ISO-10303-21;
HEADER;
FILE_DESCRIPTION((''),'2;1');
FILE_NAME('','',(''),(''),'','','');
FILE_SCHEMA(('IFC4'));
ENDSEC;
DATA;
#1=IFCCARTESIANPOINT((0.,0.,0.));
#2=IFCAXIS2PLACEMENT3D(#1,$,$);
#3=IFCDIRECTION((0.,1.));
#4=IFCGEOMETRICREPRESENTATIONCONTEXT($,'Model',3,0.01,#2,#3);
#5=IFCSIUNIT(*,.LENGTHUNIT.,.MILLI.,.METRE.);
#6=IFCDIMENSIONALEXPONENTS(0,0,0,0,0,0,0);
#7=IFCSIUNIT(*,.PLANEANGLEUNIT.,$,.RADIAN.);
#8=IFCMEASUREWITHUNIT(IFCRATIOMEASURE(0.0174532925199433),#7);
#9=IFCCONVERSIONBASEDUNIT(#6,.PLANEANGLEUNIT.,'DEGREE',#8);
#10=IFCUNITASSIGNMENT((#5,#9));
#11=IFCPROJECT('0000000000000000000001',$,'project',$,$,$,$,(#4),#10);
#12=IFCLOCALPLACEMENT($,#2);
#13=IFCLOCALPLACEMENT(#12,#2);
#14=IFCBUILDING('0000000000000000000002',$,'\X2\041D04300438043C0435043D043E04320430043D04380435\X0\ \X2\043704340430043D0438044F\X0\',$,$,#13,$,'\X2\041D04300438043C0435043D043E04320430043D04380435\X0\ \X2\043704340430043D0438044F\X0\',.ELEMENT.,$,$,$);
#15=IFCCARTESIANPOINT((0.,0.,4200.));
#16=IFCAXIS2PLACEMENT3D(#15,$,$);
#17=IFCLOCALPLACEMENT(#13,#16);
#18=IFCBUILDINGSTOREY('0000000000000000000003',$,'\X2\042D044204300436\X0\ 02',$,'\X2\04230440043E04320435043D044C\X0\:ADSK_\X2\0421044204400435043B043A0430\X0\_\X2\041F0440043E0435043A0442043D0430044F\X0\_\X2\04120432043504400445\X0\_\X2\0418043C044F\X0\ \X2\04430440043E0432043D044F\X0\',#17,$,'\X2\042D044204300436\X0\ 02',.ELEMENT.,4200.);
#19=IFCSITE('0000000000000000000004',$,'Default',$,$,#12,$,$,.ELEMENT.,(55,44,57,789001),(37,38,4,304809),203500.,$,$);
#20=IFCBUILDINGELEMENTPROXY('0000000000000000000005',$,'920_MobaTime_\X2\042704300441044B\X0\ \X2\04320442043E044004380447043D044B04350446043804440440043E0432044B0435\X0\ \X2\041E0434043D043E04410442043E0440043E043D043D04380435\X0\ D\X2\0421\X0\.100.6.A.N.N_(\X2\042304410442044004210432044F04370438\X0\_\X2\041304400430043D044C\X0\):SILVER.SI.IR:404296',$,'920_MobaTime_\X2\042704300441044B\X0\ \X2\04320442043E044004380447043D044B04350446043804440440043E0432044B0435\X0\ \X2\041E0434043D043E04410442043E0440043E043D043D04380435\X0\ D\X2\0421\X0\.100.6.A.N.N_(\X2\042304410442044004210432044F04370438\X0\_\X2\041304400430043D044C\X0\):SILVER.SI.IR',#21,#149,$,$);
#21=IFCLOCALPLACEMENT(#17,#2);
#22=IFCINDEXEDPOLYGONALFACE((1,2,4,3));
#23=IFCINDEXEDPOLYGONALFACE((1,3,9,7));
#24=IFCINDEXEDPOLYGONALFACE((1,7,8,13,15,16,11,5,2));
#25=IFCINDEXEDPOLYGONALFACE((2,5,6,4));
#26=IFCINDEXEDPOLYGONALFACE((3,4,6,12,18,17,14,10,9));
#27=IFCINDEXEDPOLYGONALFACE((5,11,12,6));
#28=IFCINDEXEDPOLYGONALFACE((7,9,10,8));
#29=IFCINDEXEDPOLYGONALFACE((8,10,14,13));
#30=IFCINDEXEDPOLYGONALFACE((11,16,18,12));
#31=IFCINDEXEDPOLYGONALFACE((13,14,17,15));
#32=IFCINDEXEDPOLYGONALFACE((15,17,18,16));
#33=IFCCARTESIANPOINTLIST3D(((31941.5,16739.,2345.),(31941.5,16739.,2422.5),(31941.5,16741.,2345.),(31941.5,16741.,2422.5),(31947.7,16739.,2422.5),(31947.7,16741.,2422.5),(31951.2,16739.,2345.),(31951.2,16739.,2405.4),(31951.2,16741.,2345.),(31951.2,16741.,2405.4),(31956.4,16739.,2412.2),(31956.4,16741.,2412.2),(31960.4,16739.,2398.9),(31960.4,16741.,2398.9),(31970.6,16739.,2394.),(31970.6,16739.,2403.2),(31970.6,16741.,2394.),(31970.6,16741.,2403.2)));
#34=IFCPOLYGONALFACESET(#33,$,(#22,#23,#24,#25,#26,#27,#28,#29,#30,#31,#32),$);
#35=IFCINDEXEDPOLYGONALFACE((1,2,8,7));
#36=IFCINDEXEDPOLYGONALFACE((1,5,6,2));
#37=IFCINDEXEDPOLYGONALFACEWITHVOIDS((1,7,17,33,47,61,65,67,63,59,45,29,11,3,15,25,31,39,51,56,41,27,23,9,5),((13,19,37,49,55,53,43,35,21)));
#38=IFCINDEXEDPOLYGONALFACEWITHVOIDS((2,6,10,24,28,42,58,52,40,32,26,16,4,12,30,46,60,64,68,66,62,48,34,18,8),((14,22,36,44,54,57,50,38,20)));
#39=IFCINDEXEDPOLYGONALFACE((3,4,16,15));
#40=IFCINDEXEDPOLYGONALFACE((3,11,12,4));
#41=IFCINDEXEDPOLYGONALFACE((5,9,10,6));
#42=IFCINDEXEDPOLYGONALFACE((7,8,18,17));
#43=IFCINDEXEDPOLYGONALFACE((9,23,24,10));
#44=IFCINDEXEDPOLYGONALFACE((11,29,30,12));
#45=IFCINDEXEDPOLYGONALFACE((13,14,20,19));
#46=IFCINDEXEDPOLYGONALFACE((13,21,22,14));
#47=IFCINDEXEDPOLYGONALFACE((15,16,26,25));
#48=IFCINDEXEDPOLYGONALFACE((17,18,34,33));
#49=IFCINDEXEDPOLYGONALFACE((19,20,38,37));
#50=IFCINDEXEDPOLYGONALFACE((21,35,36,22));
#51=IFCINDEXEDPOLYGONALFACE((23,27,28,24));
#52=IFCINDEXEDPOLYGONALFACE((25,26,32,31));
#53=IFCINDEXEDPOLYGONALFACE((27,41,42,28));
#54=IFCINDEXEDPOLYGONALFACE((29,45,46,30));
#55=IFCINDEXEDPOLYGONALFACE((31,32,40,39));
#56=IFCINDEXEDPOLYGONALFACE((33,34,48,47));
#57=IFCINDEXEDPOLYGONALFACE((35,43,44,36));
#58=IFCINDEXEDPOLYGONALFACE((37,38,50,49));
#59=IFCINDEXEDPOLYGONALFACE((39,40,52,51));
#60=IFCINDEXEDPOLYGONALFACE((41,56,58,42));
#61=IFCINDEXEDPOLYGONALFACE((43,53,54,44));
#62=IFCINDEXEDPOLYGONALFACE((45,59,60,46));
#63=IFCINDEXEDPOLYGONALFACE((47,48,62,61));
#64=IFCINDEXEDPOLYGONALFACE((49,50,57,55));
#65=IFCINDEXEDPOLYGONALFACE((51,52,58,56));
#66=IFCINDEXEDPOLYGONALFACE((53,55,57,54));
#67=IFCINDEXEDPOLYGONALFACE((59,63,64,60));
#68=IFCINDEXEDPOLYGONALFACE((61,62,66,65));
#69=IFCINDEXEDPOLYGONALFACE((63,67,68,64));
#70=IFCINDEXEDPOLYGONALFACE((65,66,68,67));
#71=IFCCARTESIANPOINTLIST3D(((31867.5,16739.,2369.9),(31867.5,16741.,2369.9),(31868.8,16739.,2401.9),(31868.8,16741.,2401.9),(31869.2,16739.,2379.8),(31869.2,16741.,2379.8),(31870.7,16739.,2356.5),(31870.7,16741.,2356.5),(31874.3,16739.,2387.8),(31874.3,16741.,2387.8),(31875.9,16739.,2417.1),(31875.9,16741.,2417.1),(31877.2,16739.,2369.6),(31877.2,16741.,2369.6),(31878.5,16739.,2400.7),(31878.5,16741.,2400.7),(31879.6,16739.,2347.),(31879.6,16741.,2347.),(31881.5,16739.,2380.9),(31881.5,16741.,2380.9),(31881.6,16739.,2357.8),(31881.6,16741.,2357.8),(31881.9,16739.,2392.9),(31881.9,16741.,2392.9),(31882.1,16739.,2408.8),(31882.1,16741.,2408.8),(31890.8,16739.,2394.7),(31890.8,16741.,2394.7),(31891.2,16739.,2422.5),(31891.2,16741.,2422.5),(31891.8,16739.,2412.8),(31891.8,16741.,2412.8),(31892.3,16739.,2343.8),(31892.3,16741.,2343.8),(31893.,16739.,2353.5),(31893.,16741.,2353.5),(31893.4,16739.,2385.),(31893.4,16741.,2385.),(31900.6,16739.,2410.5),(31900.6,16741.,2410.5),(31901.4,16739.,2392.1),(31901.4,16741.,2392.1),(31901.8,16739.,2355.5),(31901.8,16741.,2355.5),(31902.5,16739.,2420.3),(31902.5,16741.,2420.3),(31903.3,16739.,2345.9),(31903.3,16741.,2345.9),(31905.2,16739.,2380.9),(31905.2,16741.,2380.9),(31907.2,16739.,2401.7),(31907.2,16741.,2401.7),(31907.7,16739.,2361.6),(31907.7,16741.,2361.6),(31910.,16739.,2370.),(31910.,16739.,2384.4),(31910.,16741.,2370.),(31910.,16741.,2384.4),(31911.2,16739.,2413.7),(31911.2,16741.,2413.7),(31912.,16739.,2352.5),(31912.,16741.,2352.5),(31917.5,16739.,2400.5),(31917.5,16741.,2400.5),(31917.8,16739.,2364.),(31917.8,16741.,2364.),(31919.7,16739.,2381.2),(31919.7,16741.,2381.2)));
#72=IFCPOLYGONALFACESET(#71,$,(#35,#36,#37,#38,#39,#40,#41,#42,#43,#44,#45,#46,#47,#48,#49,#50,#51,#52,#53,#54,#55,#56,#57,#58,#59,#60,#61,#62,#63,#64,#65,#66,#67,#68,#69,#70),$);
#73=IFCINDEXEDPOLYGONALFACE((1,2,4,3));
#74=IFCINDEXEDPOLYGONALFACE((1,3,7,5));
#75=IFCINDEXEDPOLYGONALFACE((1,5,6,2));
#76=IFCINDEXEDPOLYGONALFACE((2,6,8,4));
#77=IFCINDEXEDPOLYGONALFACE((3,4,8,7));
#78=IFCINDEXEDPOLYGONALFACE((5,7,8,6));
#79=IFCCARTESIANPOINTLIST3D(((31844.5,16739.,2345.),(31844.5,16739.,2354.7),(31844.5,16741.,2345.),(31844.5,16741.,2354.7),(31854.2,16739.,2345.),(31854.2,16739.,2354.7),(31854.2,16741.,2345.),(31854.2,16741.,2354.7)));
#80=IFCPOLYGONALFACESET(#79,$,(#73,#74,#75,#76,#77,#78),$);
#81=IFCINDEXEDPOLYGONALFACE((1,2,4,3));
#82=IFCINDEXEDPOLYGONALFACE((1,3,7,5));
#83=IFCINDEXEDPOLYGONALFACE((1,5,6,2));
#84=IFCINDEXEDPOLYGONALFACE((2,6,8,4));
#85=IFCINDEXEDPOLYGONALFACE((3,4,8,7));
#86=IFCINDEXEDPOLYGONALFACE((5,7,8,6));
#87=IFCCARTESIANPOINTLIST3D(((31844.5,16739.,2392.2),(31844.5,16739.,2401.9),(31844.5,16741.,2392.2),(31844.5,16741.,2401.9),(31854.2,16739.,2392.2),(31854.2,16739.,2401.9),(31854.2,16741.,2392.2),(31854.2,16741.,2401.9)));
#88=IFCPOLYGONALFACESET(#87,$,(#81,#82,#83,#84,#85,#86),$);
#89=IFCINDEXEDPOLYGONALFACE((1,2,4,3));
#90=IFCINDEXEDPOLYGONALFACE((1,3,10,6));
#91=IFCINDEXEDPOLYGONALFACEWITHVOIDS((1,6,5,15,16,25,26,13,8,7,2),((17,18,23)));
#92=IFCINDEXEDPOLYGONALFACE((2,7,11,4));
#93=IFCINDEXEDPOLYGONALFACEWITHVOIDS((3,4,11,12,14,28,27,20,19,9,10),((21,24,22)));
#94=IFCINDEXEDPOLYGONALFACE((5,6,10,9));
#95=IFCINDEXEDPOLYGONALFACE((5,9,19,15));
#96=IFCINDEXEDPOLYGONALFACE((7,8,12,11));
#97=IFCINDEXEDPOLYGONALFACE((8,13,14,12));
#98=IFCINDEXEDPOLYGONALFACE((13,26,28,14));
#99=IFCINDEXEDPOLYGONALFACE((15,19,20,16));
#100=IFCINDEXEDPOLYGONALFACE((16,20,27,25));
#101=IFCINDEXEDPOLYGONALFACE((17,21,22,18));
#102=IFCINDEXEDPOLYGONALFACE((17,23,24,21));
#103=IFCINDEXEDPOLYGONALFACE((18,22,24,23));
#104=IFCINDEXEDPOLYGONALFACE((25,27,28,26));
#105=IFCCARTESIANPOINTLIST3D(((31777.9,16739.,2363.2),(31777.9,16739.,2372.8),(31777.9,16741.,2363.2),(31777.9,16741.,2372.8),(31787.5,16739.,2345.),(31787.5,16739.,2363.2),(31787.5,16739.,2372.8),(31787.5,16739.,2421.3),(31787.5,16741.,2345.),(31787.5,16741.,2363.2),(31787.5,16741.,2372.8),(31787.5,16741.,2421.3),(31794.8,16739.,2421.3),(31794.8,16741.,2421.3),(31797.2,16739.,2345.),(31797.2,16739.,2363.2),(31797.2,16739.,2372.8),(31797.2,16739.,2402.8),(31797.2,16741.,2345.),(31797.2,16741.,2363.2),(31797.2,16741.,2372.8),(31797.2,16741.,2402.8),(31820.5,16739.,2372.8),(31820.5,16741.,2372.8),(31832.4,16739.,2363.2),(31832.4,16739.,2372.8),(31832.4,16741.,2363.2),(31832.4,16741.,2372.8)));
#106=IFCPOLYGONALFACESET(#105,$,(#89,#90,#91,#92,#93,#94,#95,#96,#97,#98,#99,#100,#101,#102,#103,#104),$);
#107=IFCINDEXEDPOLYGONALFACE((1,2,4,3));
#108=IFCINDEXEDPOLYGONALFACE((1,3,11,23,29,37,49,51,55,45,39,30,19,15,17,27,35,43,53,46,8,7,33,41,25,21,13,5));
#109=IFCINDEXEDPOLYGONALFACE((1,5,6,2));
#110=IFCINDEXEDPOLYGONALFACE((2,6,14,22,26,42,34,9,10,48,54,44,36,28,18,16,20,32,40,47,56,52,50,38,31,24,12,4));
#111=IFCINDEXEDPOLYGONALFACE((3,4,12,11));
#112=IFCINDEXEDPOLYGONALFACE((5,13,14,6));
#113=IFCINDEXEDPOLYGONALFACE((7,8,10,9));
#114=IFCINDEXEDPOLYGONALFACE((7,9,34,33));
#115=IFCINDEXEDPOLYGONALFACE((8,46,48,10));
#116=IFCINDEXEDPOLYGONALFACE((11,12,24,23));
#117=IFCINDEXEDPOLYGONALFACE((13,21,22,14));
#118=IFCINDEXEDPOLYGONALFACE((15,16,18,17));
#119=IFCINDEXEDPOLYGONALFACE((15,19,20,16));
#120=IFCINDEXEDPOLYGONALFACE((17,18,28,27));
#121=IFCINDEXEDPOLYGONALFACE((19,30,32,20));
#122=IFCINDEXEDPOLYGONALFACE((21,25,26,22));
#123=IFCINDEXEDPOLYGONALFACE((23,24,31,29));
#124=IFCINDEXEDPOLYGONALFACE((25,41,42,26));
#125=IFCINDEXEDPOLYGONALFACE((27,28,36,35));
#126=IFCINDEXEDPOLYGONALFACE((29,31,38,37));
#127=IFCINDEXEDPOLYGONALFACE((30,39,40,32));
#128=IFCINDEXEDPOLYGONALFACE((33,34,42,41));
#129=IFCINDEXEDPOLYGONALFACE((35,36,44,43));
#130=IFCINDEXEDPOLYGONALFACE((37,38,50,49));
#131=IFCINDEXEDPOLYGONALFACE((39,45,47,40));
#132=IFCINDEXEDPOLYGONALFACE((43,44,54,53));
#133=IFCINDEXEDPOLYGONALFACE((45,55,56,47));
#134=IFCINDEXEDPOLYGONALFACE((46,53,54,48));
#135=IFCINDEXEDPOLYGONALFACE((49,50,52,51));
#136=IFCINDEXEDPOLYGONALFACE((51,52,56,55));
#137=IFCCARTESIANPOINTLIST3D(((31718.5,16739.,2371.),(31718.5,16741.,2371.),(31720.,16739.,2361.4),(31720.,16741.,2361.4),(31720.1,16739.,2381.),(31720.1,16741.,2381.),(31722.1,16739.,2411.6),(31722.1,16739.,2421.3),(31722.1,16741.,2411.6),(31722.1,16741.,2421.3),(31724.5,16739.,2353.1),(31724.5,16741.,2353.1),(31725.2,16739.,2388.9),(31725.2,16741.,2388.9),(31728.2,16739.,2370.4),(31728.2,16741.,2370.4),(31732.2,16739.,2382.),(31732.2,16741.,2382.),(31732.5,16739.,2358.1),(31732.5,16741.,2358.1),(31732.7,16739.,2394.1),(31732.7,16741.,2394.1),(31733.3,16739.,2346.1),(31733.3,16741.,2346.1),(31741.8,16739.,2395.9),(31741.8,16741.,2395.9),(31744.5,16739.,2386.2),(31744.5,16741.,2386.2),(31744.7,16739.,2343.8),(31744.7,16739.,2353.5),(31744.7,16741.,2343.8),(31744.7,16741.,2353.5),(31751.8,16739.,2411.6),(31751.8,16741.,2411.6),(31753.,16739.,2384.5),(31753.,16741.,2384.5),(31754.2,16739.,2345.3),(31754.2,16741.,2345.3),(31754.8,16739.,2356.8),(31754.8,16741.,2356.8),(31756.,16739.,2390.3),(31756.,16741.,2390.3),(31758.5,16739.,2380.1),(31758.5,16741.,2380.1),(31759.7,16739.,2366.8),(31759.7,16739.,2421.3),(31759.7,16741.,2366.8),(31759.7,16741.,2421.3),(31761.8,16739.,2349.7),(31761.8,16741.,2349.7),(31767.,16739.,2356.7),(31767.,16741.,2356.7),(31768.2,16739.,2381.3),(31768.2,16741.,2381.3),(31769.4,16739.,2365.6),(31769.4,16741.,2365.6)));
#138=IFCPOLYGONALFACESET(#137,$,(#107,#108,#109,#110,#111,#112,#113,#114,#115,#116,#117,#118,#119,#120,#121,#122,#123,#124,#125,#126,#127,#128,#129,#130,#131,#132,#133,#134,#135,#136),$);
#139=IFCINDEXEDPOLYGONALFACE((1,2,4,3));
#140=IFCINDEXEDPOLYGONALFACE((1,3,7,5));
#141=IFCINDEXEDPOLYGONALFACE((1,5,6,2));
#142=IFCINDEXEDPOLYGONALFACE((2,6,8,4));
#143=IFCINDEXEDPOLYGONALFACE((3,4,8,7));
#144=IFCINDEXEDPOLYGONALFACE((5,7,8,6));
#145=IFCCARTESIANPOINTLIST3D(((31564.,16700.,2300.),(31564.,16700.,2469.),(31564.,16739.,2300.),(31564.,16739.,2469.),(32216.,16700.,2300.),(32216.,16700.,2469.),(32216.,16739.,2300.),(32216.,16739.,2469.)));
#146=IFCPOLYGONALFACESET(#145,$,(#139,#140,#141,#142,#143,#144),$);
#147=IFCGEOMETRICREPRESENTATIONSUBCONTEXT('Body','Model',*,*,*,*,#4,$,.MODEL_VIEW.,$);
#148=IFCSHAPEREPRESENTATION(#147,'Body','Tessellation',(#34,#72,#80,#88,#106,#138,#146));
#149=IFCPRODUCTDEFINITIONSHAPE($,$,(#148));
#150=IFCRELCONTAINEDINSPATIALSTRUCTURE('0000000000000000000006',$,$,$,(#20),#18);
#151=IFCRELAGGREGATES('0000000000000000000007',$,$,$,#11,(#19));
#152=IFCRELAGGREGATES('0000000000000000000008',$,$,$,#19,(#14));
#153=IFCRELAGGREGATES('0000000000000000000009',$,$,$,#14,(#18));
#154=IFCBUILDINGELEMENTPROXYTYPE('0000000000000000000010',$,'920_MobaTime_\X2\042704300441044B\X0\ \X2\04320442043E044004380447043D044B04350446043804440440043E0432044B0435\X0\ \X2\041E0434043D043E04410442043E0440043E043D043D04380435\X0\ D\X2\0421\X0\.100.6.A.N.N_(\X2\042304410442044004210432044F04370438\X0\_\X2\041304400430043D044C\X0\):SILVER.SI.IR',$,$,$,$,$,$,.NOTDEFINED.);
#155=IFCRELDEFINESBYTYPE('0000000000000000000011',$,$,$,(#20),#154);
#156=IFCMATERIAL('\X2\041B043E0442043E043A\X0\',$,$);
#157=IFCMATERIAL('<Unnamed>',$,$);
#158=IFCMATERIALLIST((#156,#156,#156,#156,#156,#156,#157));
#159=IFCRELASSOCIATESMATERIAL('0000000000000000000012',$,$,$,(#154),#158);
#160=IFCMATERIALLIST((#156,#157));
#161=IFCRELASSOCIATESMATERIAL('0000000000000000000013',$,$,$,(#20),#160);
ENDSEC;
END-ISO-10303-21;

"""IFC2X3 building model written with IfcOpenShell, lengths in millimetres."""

from ifc_helpers import new_model, entity, si_unit, converted_unit, direction, frame, origin, origin_2d_with_axis, place, context, subcontext, project, spatial, polyline, rectangle, outline, extrude, source, transform, mapped, material, material_list, type_object, type_shapes, element, save


model = new_model("IFC2X3")

# Units and contexts
model_context = context("Model", 3, precision=0.01, world=origin(), true_north=direction((0.0, 1.0)))
body_context = subcontext(model_context, "Body", "Model", "MODEL_VIEW")
ifc_project = project(units=[si_unit("LENGTHUNIT", "METRE", prefix="MILLI"), converted_unit("PLANEANGLEUNIT", "DEGREE", entity("IfcRatioMeasure", 0.0174532925199433), si_unit("PLANEANGLEUNIT", "RADIAN"), dimensions=[0, 0, 0, 0, 0, 0, 0])], contexts=[model_context])

# Site, building, storey
site_placement = place(None, frame((0.0, 0.0, 0.0)))
site = spatial("IfcSite", under=ifc_project, at=site_placement, Name="Default", CompositionType="ELEMENT", RefLatitude=(55, 44, 57, 789001), RefLongitude=(37, 38, 4, 304809), RefElevation=203500.0)
building_placement = place(site_placement, origin())
building = spatial("IfcBuilding", under=site, at=building_placement, Name="Наименование здания", LongName="Наименование здания", CompositionType="ELEMENT")
storey_placement = place(building_placement, frame((0.0, 0.0, 4200.0)))
storey = spatial("IfcBuildingStorey", under=building, at=storey_placement, Name="Этаж 02", ObjectType="Уровень:ADSK_Стрелка_Проектная_Вверх_Имя уровня", LongName="Этаж 02", CompositionType="ELEMENT", Elevation=4200.0)

# Building element proxy
ifc_material_1 = material(Name="Лоток")
ifc_material_2 = material(Name="<Unnamed>")
ifc_material_list_1 = material_list([ifc_material_1, ifc_material_1, ifc_material_1, ifc_material_1, ifc_material_1, ifc_material_1, ifc_material_2])
building_element_proxy_type_1 = type_object("IfcBuildingElementProxyType", Name="920_MobaTime_Часы вторичныецифровые Односторонние DС.100.6.A.N.N_(УстрСвязи_Грань):SILVER.SI.IR", PredefinedType="NOTDEFINED", material=ifc_material_list_1)
shared_shape_1 = source(origin(), body_context, "Body", "SweptSolid", [
    extrude(outline(polyline([(-49.3, -13.1), (28.2, -13.1), (28.2, -6.8), (17.9, 1.8), (8.9, 16.0), (-0.3, 16.0), (4.6, 5.8), (11.1, -3.4), (-49.3, -3.4), (-49.3, -13.1)])), frame((-64.6, 9.8, 39.0), z_axis=(0.0, 0.0, 1.0), x_axis=(0.0, 1.0, 0.0)), (0.0, 0.0, 1.0), 2.0),
    extrude(outline(polyline([(2.2, -27.6), (19.0, -27.6), (30.5, -16.1), (33.3, -4.9), (31.0, 5.8), (21.8, 17.2), (5.2, 27.3), (-11.1, 33.0), (-24.0, 32.7), (-33.6, 27.6), (-40.3, 18.6), (-42.8, 5.7), (-38.0, -6.3), (-27.2, -15.0), (-17.5, -17.7), (-8.2, -16.4), (-0.3, -11.9), (5.1, -4.5), (7.3, 6.2), (4.0, 17.2), (18.5, 7.3), (23.6, -2.4), (22.0, -11.4), (14.2, -18.4), (5.3, -18.3), (2.2, -27.6)]), holes=[polyline([(-9.0, 23.3), (-1.3, 14.4), (-2.6, 2.0), (-11.4, -7.0), (-23.4, -6.1), (-32.2, 2.9), (-31.2, 15.1), (-25.6, 22.1), (-17.5, 24.9), (-9.0, 23.3)])]), frame((-2.7, 3.6, 39.0), z_axis=(0.0, 0.0, 1.0), x_axis=(-0.427649, 0.903945, 0.0)), (0.0, 0.0, 1.0), 2.0),
    extrude(rectangle(XDim=9.7, YDim=9.7, at=origin_2d_with_axis()), frame((40.6, -34.7, 39.0)), (0.0, 0.0, 1.0), 2.0),
    extrude(rectangle(XDim=9.7, YDim=9.7, at=origin_2d_with_axis()), frame((40.6, 12.6, 39.0)), (0.0, 0.0, 1.0), 2.0),
    extrude(outline(polyline([(-0.9, -28.1), (8.8, -28.1), (8.8, -9.9), (18.5, -9.9), (18.5, -0.2), (8.8, -0.2), (8.8, 48.3), (1.5, 48.3), (-36.0, -0.2), (-36.0, -9.9), (-0.9, -9.9), (-0.9, -28.1)]), holes=[polyline([(-0.9, -0.2), (-24.1, -0.2), (-0.9, 29.7), (-0.9, -0.2)])]), frame((93.6, -11.4, 39.0)), (0.0, 0.0, 1.0), 2.0),
    extrude(outline(polyline([(3.3, -28.3), (12.5, -28.3), (20.5, -25.0), (26.8, -18.8), (30.7, -10.0), (31.4, 1.6), (26.9, 11.8), (20.1, 18.4), (11.1, 22.3), (1.0, 23.3), (-7.9, 20.4), (-14.9, 14.5), (-18.9, 6.2), (-17.1, -9.0), (-36.7, 0.5), (-29.1, 29.3), (-38.5, 31.7), (-48.1, -4.6), (-11.6, -23.0), (-8.0, -14.0), (-10.8, -7.6), (-10.2, 1.1), (-3.0, 11.8), (9.2, 12.8), (20.0, 5.4), (21.3, -7.5), (15.5, -16.4), (4.6, -18.6), (3.3, -28.3)])), frame((147.1, -8.5, 39.0), z_axis=(0.0, 0.0, 1.0), x_axis=(0.256974, -0.966418, 0.0)), (0.0, 0.0, 1.0), 2.0),
    extrude(rectangle(XDim=652.0, YDim=169.0, at=origin_2d_with_axis()), frame((0.0, 0.0, 0.0), z_axis=(0.0, 0.0, 1.0), x_axis=(-1.0, 0.0, 0.0)), (0.0, 0.0, 1.0), 39.0),
])
type_shapes(building_element_proxy_type_1, [shared_shape_1])
ifc_material_list_2 = material_list([ifc_material_1, ifc_material_2])
proxy_1_placement = place(storey_placement, frame((31890.0, 16700.0, 2384.5), z_axis=(0.0, 1.0, 0.0), x_axis=(-1.0, 0.0, 0.0)))
element("IfcBuildingElementProxy", 1, at=proxy_1_placement, inside=storey, type_object=building_element_proxy_type_1, material=ifc_material_list_2, Name="920_MobaTime_Часы вторичныецифровые Односторонние DС.100.6.A.N.N_(УстрСвязи_Грань):SILVER.SI.IR:404296", ObjectType="920_MobaTime_Часы вторичныецифровые Односторонние DС.100.6.A.N.N_(УстрСвязи_Грань):SILVER.SI.IR", context=body_context, shape_type="MappedRepresentation", body=[
    mapped(shared_shape_1, transform((0.0, 0.0, 0.0), scale=1.0)),
])

save(model, "model.ifc")
